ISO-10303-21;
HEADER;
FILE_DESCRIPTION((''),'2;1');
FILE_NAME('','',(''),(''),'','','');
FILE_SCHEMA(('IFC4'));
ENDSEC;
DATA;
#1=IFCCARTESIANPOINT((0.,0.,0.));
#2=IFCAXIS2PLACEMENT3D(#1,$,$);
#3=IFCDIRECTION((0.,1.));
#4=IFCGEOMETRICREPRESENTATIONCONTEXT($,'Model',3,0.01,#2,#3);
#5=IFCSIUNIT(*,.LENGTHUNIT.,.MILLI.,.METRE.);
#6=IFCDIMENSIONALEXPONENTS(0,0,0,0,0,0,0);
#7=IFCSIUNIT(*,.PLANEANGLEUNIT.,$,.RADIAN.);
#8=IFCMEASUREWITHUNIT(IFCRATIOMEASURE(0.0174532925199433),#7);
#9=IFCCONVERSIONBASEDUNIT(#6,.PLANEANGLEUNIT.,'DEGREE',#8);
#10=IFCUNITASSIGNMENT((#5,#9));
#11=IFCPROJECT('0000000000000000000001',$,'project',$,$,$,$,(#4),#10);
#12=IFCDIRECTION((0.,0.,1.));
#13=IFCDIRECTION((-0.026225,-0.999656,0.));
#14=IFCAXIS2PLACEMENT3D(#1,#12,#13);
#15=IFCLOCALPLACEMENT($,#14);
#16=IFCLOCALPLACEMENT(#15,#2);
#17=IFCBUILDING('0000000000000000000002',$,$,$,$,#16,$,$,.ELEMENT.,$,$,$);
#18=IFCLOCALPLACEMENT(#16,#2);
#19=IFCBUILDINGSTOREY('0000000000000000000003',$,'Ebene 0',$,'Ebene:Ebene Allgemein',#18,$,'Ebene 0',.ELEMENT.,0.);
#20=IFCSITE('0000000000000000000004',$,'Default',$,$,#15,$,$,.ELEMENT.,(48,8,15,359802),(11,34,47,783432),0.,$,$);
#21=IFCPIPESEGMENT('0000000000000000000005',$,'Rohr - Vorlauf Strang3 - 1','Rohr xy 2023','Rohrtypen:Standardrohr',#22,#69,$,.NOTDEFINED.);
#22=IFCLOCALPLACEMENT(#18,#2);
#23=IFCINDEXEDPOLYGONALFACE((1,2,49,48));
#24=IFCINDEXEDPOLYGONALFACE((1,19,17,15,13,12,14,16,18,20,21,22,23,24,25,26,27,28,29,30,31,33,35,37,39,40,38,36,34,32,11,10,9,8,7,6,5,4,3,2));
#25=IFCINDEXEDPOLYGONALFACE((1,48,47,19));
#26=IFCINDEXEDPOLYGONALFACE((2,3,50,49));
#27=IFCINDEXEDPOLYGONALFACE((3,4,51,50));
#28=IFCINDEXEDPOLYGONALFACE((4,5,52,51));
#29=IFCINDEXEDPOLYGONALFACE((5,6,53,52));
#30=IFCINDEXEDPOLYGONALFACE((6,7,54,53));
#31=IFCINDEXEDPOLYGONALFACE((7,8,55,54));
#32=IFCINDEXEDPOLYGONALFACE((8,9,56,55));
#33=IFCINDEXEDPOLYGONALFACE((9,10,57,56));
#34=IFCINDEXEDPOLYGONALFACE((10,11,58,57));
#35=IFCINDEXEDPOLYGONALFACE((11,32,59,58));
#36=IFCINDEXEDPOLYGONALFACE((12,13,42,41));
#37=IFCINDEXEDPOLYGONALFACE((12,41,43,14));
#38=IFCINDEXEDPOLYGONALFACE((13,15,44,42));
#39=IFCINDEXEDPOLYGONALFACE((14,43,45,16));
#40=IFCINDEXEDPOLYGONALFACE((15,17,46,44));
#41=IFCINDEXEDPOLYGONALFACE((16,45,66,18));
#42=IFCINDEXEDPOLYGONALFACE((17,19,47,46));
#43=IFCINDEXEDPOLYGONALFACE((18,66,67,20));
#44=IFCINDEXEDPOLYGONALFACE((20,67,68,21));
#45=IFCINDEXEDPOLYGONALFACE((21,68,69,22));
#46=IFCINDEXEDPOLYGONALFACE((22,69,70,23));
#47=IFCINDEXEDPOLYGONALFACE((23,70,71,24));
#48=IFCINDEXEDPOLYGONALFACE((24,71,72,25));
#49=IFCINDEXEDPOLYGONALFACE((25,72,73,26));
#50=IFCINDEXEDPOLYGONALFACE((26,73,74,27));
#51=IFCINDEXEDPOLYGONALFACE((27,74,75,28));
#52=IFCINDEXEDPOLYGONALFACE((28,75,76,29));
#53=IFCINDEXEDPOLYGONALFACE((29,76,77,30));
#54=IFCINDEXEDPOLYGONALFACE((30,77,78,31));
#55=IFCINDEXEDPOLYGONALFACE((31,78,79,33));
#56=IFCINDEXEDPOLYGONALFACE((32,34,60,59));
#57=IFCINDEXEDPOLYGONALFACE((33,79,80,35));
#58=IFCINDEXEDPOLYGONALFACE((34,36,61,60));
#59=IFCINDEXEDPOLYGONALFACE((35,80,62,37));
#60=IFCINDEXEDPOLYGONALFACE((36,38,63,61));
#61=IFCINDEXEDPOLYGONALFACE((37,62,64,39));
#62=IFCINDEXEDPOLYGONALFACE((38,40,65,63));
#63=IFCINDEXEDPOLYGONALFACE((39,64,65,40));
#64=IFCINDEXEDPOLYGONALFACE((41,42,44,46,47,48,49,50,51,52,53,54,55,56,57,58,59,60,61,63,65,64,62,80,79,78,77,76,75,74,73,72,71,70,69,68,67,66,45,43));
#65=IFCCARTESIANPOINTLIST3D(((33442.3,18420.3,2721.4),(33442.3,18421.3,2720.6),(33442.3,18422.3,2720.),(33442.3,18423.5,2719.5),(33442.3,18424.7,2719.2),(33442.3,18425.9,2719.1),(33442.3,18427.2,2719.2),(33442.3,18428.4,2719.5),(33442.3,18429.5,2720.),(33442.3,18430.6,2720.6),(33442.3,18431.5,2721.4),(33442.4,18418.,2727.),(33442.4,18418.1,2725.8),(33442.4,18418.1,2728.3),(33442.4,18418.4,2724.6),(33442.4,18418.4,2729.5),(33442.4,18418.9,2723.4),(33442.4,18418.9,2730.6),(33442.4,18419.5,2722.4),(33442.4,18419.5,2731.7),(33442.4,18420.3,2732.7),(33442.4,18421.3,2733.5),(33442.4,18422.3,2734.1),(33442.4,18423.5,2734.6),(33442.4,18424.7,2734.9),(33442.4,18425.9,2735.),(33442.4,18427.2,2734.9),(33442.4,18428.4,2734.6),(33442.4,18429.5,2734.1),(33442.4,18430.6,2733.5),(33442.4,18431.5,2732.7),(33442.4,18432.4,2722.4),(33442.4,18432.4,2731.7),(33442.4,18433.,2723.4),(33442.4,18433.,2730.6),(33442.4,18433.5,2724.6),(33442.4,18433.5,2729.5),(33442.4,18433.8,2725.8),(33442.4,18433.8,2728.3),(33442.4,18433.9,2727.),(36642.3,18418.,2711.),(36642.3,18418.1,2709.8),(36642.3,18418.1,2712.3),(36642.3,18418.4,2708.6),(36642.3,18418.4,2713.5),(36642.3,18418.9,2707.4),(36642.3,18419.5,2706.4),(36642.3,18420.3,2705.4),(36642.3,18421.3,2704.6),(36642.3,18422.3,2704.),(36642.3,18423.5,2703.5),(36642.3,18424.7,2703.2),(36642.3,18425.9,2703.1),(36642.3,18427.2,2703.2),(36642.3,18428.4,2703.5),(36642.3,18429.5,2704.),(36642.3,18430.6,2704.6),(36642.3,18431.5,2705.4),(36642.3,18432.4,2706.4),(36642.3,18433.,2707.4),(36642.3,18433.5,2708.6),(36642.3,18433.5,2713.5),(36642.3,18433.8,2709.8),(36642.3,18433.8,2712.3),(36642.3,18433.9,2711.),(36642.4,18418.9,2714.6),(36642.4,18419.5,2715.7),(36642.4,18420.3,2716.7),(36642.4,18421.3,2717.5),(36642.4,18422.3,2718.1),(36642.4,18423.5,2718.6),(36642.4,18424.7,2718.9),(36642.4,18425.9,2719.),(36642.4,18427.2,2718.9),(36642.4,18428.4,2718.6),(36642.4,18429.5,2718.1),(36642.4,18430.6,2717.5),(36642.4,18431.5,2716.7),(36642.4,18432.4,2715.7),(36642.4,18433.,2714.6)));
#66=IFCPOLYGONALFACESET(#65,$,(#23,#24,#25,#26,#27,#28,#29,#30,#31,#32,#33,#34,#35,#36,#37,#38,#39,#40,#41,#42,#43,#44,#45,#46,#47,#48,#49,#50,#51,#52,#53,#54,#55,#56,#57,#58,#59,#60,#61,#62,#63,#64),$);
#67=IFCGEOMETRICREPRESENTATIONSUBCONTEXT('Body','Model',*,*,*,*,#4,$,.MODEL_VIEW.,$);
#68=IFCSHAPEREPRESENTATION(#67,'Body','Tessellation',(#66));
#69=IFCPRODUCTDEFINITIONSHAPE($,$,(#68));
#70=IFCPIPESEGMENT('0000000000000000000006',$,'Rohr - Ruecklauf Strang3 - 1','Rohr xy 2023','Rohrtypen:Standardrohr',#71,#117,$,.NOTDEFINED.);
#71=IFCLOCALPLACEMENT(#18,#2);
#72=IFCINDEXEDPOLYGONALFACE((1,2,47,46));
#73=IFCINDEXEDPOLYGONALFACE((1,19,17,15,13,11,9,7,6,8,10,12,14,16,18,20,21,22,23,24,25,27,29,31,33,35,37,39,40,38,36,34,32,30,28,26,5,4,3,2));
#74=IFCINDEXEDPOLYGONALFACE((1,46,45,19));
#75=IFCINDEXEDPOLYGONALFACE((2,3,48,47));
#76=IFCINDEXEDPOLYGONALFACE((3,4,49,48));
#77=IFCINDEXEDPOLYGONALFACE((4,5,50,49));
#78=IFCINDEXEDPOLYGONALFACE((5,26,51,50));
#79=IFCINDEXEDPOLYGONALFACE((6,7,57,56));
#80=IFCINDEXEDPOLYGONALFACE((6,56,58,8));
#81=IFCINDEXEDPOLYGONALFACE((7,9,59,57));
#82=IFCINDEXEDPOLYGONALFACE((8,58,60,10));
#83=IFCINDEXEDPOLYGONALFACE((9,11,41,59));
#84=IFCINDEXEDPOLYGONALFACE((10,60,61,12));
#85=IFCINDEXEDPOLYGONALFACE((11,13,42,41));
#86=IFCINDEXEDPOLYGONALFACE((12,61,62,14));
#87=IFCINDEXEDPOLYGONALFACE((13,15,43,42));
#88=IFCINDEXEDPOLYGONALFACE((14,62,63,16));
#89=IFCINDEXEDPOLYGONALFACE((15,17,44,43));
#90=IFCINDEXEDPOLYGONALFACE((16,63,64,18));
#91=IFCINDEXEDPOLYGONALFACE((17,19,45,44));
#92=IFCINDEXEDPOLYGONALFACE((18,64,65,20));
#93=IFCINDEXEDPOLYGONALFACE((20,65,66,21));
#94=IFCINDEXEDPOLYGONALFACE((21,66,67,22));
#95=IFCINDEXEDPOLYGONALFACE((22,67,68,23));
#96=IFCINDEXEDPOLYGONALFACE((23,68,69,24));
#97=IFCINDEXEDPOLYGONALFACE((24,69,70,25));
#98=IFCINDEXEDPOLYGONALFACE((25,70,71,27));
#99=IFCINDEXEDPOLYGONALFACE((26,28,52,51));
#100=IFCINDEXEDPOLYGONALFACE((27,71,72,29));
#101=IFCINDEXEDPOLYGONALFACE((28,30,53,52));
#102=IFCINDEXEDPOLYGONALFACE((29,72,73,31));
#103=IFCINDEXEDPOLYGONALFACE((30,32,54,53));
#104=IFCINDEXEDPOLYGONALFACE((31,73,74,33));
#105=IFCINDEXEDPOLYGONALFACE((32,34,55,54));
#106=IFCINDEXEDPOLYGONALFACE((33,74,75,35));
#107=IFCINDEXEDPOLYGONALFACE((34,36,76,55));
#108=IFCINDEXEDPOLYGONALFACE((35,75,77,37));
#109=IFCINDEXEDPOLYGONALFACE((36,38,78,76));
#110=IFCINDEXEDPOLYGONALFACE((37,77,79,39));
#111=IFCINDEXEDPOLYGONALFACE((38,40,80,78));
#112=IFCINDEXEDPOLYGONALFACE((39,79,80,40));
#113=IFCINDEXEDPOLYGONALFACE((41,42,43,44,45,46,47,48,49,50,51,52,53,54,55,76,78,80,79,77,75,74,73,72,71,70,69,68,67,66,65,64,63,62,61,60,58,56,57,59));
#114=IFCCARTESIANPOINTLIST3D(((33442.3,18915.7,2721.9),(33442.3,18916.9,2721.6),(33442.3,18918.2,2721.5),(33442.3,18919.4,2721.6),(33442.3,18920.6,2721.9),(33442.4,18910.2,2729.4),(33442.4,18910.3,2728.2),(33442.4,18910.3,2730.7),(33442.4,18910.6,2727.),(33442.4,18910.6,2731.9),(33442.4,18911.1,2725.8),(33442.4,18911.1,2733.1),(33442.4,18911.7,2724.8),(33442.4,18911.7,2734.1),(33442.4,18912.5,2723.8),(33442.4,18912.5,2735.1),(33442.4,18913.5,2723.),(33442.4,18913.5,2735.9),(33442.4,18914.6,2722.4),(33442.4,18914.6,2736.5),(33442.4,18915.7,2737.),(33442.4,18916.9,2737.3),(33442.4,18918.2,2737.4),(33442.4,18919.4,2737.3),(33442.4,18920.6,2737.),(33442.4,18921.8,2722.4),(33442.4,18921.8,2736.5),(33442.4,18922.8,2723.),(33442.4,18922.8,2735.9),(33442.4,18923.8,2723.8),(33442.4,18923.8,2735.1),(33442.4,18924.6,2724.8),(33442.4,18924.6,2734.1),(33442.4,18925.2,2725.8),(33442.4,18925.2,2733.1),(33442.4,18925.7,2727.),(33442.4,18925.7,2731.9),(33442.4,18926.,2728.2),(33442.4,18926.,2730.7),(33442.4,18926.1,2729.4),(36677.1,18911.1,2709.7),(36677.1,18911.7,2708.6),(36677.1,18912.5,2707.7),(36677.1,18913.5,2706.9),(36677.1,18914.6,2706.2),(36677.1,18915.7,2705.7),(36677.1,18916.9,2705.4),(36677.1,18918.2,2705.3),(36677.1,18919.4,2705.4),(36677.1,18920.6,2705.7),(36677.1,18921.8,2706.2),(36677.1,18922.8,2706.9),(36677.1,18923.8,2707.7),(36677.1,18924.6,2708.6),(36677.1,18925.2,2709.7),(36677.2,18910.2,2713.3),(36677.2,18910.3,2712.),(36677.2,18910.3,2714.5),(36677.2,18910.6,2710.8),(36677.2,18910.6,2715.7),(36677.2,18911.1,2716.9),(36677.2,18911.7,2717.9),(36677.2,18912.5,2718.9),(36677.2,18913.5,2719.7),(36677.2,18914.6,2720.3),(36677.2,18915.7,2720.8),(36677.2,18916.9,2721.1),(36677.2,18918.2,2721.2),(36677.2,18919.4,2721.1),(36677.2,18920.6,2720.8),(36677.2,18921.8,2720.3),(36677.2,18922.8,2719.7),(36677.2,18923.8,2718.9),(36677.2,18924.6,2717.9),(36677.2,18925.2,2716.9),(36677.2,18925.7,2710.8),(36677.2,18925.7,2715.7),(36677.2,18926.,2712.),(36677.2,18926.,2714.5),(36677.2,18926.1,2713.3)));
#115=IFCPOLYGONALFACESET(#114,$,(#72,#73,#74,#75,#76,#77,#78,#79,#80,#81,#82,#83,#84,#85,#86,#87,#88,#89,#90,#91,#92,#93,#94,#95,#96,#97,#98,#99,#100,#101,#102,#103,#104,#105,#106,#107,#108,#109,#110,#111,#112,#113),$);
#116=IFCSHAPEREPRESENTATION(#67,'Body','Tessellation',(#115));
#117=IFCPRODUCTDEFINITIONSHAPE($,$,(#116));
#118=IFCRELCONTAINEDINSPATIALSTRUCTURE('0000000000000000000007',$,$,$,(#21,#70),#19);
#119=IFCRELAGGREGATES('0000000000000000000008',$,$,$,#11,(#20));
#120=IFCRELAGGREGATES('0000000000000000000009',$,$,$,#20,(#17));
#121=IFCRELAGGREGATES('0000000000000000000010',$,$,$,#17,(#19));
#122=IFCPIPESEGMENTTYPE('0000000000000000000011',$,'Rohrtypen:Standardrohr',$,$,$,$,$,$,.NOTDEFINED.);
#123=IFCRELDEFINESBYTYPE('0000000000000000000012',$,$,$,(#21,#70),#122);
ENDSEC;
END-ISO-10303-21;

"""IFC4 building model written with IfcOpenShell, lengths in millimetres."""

from ifc_helpers import new_model, entity, si_unit, converted_unit, direction, frame, origin, place, context, subcontext, project, spatial, indexed_curve, outline, extrude, type_object, element, save


model = new_model("IFC4")

# Units and contexts
model_context = context("Model", 3, precision=0.01, world=origin(), true_north=direction((0.0, 1.0)))
body_context = subcontext(model_context, "Body", "Model", "MODEL_VIEW")
ifc_project = project(units=[si_unit("LENGTHUNIT", "METRE", prefix="MILLI"), converted_unit("PLANEANGLEUNIT", "DEGREE", entity("IfcRatioMeasure", 0.0174532925199433), si_unit("PLANEANGLEUNIT", "RADIAN"), dimensions=[0, 0, 0, 0, 0, 0, 0])], contexts=[model_context])

# Site, building, storey
site_placement = place(None, frame((0.0, 0.0, 0.0), z_axis=(0.0, 0.0, 1.0), x_axis=(-0.026225, -0.999656, 0.0)))
site = spatial("IfcSite", under=ifc_project, at=site_placement, Name="Default", CompositionType="ELEMENT", RefLatitude=(48, 8, 15, 359802), RefLongitude=(11, 34, 47, 783432), RefElevation=0.0)
building_placement = place(site_placement, origin())
building = spatial("IfcBuilding", under=site, at=building_placement, CompositionType="ELEMENT")
storey_placement = place(building_placement, origin())
storey = spatial("IfcBuildingStorey", under=building, at=storey_placement, Name="Ebene 0", ObjectType="Ebene:Ebene Allgemein", LongName="Ebene 0", CompositionType="ELEMENT", Elevation=0.0)

# Pipe segments
pipe_segment_type = type_object("IfcPipeSegmentType", Name="Rohrtypen:Standardrohr", PredefinedType="NOTDEFINED")
pipe_segment_1_placement = place(storey_placement, origin())
element("IfcPipeSegment", 1, at=pipe_segment_1_placement, inside=storey, type_object=pipe_segment_type, Name="Rohr - Vorlauf Strang3 - 1", Description="Rohr xy 2023", ObjectType="Rohrtypen:Standardrohr", PredefinedType="NOTDEFINED", context=body_context, shape_type="SweptSolid", body=[
    extrude(outline(indexed_curve([(7.9, 0.0), (7.8, 1.2), (7.6, 2.5), (7.1, 3.6), (6.4, 4.7), (5.6, 5.6), (4.7, 6.4), (3.6, 7.1), (2.5, 7.6), (1.2, 7.8), (0.0, 7.9), (-1.2, 7.8), (-2.5, 7.6), (-3.6, 7.1), (-4.7, 6.4), (-5.6, 5.6), (-6.4, 4.7), (-7.1, 3.6), (-7.6, 2.5), (-7.8, 1.2), (-7.9, 0.0), (-7.8, -1.2), (-7.6, -2.5), (-7.1, -3.6), (-6.4, -4.7), (-5.6, -5.6), (-4.7, -6.4), (-3.6, -7.1), (-2.5, -7.6), (-1.2, -7.8), (0.0, -7.9), (1.2, -7.8), (2.5, -7.6), (3.6, -7.1), (4.7, -6.4), (5.6, -5.6), (6.4, -4.7), (7.1, -3.6), (7.6, -2.5), (7.8, -1.2), (7.9, 0.0)], self_intersect=False)), frame((36642.3, 18425.9, 2711.0), z_axis=(-0.999988, 0.0, 0.005), x_axis=(0.0, 1.0, 0.0)), (0.0, 0.0, 1.0), 3200.0),
])
pipe_segment_2_placement = place(storey_placement, origin())
element("IfcPipeSegment", 2, at=pipe_segment_2_placement, inside=storey, type_object=pipe_segment_type, Name="Rohr - Ruecklauf Strang3 - 1", Description="Rohr xy 2023", ObjectType="Rohrtypen:Standardrohr", PredefinedType="NOTDEFINED", context=body_context, shape_type="SweptSolid", body=[
    extrude(outline(indexed_curve([(7.9, 0.0), (7.8, 1.2), (7.6, 2.5), (7.1, 3.6), (6.4, 4.7), (5.6, 5.6), (4.7, 6.4), (3.6, 7.1), (2.5, 7.6), (1.2, 7.8), (0.0, 7.9), (-1.2, 7.8), (-2.5, 7.6), (-3.6, 7.1), (-4.7, 6.4), (-5.6, 5.6), (-6.4, 4.7), (-7.1, 3.6), (-7.6, 2.5), (-7.8, 1.2), (-7.9, 0.0), (-7.8, -1.2), (-7.6, -2.5), (-7.1, -3.6), (-6.4, -4.7), (-5.6, -5.6), (-4.7, -6.4), (-3.6, -7.1), (-2.5, -7.6), (-1.2, -7.8), (0.0, -7.9), (1.2, -7.8), (2.5, -7.6), (3.6, -7.1), (4.7, -6.4), (5.6, -5.6), (6.4, -4.7), (7.1, -3.6), (7.6, -2.5), (7.8, -1.2), (7.9, 0.0)], self_intersect=False)), frame((36677.2, 18918.2, 2713.3), z_axis=(-0.999988, 0.0, 0.005), x_axis=(0.0, 1.0, 0.0)), (0.0, 0.0, 1.0), 3234.8),
])

save(model, "model.ifc")
